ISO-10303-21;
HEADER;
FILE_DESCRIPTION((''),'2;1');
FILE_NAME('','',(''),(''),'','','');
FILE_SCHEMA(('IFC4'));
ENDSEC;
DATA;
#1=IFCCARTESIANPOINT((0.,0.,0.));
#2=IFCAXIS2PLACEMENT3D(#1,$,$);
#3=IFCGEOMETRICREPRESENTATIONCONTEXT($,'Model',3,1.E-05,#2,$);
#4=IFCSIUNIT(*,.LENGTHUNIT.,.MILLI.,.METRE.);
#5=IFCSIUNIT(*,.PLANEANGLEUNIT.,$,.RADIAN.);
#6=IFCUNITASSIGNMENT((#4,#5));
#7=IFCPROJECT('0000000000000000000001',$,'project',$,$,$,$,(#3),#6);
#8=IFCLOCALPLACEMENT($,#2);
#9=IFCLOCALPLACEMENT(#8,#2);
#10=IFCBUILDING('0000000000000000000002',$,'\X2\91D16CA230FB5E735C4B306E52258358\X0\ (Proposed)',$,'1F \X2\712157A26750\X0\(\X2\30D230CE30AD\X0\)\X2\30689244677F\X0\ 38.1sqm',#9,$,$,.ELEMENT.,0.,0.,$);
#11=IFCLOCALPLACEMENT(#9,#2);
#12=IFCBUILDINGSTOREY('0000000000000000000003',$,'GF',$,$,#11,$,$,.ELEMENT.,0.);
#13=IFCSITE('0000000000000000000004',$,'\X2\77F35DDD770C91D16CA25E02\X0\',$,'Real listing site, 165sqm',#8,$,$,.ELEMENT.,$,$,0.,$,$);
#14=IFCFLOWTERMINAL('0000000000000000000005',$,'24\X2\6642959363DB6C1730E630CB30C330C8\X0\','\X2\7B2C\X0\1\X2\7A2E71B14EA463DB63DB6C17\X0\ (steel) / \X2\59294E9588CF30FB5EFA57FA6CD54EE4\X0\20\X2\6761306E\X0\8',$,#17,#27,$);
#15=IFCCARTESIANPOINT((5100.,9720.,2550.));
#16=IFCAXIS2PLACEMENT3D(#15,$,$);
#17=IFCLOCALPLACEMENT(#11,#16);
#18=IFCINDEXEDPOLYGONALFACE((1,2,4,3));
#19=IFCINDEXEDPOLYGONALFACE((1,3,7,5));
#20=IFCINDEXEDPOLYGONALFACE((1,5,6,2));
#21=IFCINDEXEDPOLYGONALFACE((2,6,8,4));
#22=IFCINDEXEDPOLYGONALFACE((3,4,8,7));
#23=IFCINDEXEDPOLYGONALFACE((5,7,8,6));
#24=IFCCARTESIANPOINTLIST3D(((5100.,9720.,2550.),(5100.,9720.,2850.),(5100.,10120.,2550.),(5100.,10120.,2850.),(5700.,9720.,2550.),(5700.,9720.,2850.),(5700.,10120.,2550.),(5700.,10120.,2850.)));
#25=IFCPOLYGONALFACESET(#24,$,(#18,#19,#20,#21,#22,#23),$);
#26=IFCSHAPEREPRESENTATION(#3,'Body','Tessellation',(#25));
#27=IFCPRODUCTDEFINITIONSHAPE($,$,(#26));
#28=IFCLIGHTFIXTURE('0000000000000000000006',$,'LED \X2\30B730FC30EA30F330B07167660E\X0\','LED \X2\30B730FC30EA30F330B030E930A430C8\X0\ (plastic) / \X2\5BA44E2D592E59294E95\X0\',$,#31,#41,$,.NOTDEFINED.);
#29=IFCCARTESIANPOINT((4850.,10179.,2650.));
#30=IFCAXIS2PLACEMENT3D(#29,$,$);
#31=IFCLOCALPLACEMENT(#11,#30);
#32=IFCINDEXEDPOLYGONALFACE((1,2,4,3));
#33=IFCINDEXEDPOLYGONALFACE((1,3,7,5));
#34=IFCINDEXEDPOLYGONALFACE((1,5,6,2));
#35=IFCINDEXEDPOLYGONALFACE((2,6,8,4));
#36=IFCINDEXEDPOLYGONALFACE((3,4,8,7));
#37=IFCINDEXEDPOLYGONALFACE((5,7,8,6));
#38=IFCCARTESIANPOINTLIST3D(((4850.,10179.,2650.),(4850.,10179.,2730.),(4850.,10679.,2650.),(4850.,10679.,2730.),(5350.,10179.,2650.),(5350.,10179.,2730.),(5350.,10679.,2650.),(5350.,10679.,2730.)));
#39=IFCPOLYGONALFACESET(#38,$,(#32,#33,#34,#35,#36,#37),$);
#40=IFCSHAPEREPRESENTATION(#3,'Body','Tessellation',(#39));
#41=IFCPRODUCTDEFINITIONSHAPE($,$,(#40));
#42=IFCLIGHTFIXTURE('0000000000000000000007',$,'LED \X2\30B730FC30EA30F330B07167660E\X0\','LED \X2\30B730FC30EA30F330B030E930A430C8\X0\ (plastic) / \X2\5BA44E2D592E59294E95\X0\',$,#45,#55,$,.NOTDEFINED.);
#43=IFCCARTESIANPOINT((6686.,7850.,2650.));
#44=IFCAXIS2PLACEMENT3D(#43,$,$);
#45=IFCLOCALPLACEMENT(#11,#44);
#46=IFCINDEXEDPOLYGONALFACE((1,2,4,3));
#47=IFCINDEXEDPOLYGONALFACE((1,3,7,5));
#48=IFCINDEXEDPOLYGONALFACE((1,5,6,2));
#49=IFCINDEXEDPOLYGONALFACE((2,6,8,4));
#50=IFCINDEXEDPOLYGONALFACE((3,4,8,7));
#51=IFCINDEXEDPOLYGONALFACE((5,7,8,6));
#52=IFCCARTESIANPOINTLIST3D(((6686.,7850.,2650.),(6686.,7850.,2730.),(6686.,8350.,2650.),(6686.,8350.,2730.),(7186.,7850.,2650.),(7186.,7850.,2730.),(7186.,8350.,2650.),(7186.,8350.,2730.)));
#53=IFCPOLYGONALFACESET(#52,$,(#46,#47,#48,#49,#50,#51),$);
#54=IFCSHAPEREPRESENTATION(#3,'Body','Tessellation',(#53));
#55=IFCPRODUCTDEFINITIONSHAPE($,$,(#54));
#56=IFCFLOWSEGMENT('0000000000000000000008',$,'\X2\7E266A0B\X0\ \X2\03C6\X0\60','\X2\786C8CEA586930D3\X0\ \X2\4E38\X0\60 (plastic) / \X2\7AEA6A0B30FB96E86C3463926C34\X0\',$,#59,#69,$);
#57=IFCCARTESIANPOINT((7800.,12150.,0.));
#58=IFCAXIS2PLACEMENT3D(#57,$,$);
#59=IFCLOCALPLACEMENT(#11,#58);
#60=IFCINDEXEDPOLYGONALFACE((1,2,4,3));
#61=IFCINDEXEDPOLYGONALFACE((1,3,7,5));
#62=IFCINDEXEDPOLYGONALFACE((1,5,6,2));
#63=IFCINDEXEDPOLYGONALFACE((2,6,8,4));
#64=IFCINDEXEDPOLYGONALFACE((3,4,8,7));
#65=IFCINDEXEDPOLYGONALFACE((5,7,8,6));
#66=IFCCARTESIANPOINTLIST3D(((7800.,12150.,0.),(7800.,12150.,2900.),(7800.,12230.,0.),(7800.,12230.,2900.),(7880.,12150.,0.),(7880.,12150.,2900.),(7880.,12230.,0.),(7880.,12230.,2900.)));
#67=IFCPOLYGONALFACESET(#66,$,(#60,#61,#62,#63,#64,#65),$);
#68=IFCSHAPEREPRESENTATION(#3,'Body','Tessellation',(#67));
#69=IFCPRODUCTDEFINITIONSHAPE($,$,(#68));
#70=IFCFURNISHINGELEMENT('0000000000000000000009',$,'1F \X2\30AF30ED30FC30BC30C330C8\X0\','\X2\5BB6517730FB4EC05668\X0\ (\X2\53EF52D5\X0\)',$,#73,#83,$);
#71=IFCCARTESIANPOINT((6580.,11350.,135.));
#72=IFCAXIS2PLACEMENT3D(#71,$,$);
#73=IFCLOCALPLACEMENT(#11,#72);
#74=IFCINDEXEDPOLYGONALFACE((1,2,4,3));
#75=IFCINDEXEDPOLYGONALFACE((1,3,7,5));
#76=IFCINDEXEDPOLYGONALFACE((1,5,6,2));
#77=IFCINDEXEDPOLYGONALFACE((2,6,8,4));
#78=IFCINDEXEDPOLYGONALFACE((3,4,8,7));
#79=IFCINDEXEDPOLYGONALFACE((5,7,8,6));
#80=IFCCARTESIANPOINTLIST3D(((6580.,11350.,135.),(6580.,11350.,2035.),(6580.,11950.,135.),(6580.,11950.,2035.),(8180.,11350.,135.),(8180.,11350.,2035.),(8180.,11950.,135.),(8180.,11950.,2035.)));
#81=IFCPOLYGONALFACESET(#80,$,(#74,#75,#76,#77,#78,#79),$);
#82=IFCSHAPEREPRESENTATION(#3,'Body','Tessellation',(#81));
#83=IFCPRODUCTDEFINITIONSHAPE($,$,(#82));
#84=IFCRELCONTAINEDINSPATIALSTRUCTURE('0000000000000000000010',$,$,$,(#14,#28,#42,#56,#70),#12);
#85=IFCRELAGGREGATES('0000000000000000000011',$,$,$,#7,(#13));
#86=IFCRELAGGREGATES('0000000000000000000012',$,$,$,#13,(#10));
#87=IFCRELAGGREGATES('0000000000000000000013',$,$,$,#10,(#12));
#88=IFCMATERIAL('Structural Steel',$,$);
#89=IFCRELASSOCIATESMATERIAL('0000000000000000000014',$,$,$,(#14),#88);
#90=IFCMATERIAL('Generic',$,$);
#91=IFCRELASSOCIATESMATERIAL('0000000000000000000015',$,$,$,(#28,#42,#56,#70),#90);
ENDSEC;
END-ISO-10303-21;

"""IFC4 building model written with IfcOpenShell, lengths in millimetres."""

from ifc_helpers import new_model, si_unit, frame, frame_2d, origin, place, context, project, spatial, rectangle, extrude, material, element, save


model = new_model("IFC4")

# Units and contexts
model_context = context("Model", 3, precision=1e-05, world=origin())
ifc_project = project(units=[si_unit("LENGTHUNIT", "METRE", prefix="MILLI"), si_unit("PLANEANGLEUNIT", "RADIAN")], contexts=[model_context])

# Site, building, storey
site_placement = place(None, origin())
site = spatial("IfcSite", under=ifc_project, at=site_placement, Name="石川県金沢市", ObjectType="Real listing site, 165sqm", CompositionType="ELEMENT", RefElevation=0.0)
building_placement = place(site_placement, origin())
building = spatial("IfcBuilding", under=site, at=building_placement, Name="金沢・平屋の別荘 (Proposed)", ObjectType="1F 無垢材(ヒノキ)と鉄板 38.1sqm", CompositionType="ELEMENT", ElevationOfRefHeight=0.0, ElevationOfTerrain=0.0)
storey_placement = place(building_placement, origin())
storey = spatial("IfcBuildingStorey", under=building, at=storey_placement, Name="GF", CompositionType="ELEMENT", Elevation=0.0)

# Shared definitions
ifc_material_1 = material(Name="Generic")

# Flow terminal
ifc_material_2 = material(Name="Structural Steel")
flow_terminal_placement = place(storey_placement, frame((5100.0, 9720.0, 2550.0)))
element("IfcFlowTerminal", 1, at=flow_terminal_placement, inside=storey, material=ifc_material_2, Name="24時間換気ユニット", Description="第1種熱交換換気 (steel) / 天井裏・建基法令20条の8", context=model_context, shape_type="SweptSolid", body=[
    extrude(rectangle(XDim=600.0, YDim=400.0, at=frame_2d((300.0, 200.0))), frame((5100.0, 9720.0, 2550.0)), (0.0, 0.0, 1.0), 300.0),
])

# Light fixtures
light_fixture_1_placement = place(storey_placement, frame((4850.0, 10179.0, 2650.0)))
element("IfcLightFixture", 2, at=light_fixture_1_placement, inside=storey, material=ifc_material_1, Name="LED シーリング照明", Description="LED シーリングライト (plastic) / 室中央天井", PredefinedType="NOTDEFINED", context=model_context, shape_type="SweptSolid", body=[
    extrude(rectangle(XDim=500.0, YDim=500.0, at=frame_2d((250.0, 250.0))), frame((4850.0, 10179.0, 2650.0)), (0.0, 0.0, 1.0), 80.0),
])
light_fixture_2_placement = place(storey_placement, frame((6686.0, 7850.0, 2650.0)))
element("IfcLightFixture", 3, at=light_fixture_2_placement, inside=storey, material=ifc_material_1, Name="LED シーリング照明", Description="LED シーリングライト (plastic) / 室中央天井", PredefinedType="NOTDEFINED", context=model_context, shape_type="SweptSolid", body=[
    extrude(rectangle(XDim=500.0, YDim=500.0, at=frame_2d((250.0, 250.0))), frame((6686.0, 7850.0, 2650.0)), (0.0, 0.0, 1.0), 80.0),
])

# Flow segment
flow_segment_placement = place(storey_placement, frame((7800.0, 12150.0, 0.0)))
element("IfcFlowSegment", 4, at=flow_segment_placement, inside=storey, material=ifc_material_1, Name="縦樋 φ60", Description="硬質塩ビ 丸60 (plastic) / 竪樋・雨水排水", context=model_context, shape_type="SweptSolid", body=[
    extrude(rectangle(XDim=80.0, YDim=80.0, at=frame_2d((40.0, 40.0))), frame((7800.0, 12150.0, 0.0)), (0.0, 0.0, 1.0), 2900.0),
])

# Furnishing element
furnishing_placement = place(storey_placement, frame((6580.0, 11350.0, 135.0)))
element("IfcFurnishingElement", 5, at=furnishing_placement, inside=storey, material=ifc_material_1, Name="1F クローゼット", Description="家具・什器 (可動)", context=model_context, shape_type="SweptSolid", body=[
    extrude(rectangle(XDim=1600.0, YDim=600.0, at=frame_2d((800.0, 300.0))), frame((6580.0, 11350.0, 135.0)), (0.0, 0.0, 1.0), 1900.0),
])

save(model, "model.ifc")
